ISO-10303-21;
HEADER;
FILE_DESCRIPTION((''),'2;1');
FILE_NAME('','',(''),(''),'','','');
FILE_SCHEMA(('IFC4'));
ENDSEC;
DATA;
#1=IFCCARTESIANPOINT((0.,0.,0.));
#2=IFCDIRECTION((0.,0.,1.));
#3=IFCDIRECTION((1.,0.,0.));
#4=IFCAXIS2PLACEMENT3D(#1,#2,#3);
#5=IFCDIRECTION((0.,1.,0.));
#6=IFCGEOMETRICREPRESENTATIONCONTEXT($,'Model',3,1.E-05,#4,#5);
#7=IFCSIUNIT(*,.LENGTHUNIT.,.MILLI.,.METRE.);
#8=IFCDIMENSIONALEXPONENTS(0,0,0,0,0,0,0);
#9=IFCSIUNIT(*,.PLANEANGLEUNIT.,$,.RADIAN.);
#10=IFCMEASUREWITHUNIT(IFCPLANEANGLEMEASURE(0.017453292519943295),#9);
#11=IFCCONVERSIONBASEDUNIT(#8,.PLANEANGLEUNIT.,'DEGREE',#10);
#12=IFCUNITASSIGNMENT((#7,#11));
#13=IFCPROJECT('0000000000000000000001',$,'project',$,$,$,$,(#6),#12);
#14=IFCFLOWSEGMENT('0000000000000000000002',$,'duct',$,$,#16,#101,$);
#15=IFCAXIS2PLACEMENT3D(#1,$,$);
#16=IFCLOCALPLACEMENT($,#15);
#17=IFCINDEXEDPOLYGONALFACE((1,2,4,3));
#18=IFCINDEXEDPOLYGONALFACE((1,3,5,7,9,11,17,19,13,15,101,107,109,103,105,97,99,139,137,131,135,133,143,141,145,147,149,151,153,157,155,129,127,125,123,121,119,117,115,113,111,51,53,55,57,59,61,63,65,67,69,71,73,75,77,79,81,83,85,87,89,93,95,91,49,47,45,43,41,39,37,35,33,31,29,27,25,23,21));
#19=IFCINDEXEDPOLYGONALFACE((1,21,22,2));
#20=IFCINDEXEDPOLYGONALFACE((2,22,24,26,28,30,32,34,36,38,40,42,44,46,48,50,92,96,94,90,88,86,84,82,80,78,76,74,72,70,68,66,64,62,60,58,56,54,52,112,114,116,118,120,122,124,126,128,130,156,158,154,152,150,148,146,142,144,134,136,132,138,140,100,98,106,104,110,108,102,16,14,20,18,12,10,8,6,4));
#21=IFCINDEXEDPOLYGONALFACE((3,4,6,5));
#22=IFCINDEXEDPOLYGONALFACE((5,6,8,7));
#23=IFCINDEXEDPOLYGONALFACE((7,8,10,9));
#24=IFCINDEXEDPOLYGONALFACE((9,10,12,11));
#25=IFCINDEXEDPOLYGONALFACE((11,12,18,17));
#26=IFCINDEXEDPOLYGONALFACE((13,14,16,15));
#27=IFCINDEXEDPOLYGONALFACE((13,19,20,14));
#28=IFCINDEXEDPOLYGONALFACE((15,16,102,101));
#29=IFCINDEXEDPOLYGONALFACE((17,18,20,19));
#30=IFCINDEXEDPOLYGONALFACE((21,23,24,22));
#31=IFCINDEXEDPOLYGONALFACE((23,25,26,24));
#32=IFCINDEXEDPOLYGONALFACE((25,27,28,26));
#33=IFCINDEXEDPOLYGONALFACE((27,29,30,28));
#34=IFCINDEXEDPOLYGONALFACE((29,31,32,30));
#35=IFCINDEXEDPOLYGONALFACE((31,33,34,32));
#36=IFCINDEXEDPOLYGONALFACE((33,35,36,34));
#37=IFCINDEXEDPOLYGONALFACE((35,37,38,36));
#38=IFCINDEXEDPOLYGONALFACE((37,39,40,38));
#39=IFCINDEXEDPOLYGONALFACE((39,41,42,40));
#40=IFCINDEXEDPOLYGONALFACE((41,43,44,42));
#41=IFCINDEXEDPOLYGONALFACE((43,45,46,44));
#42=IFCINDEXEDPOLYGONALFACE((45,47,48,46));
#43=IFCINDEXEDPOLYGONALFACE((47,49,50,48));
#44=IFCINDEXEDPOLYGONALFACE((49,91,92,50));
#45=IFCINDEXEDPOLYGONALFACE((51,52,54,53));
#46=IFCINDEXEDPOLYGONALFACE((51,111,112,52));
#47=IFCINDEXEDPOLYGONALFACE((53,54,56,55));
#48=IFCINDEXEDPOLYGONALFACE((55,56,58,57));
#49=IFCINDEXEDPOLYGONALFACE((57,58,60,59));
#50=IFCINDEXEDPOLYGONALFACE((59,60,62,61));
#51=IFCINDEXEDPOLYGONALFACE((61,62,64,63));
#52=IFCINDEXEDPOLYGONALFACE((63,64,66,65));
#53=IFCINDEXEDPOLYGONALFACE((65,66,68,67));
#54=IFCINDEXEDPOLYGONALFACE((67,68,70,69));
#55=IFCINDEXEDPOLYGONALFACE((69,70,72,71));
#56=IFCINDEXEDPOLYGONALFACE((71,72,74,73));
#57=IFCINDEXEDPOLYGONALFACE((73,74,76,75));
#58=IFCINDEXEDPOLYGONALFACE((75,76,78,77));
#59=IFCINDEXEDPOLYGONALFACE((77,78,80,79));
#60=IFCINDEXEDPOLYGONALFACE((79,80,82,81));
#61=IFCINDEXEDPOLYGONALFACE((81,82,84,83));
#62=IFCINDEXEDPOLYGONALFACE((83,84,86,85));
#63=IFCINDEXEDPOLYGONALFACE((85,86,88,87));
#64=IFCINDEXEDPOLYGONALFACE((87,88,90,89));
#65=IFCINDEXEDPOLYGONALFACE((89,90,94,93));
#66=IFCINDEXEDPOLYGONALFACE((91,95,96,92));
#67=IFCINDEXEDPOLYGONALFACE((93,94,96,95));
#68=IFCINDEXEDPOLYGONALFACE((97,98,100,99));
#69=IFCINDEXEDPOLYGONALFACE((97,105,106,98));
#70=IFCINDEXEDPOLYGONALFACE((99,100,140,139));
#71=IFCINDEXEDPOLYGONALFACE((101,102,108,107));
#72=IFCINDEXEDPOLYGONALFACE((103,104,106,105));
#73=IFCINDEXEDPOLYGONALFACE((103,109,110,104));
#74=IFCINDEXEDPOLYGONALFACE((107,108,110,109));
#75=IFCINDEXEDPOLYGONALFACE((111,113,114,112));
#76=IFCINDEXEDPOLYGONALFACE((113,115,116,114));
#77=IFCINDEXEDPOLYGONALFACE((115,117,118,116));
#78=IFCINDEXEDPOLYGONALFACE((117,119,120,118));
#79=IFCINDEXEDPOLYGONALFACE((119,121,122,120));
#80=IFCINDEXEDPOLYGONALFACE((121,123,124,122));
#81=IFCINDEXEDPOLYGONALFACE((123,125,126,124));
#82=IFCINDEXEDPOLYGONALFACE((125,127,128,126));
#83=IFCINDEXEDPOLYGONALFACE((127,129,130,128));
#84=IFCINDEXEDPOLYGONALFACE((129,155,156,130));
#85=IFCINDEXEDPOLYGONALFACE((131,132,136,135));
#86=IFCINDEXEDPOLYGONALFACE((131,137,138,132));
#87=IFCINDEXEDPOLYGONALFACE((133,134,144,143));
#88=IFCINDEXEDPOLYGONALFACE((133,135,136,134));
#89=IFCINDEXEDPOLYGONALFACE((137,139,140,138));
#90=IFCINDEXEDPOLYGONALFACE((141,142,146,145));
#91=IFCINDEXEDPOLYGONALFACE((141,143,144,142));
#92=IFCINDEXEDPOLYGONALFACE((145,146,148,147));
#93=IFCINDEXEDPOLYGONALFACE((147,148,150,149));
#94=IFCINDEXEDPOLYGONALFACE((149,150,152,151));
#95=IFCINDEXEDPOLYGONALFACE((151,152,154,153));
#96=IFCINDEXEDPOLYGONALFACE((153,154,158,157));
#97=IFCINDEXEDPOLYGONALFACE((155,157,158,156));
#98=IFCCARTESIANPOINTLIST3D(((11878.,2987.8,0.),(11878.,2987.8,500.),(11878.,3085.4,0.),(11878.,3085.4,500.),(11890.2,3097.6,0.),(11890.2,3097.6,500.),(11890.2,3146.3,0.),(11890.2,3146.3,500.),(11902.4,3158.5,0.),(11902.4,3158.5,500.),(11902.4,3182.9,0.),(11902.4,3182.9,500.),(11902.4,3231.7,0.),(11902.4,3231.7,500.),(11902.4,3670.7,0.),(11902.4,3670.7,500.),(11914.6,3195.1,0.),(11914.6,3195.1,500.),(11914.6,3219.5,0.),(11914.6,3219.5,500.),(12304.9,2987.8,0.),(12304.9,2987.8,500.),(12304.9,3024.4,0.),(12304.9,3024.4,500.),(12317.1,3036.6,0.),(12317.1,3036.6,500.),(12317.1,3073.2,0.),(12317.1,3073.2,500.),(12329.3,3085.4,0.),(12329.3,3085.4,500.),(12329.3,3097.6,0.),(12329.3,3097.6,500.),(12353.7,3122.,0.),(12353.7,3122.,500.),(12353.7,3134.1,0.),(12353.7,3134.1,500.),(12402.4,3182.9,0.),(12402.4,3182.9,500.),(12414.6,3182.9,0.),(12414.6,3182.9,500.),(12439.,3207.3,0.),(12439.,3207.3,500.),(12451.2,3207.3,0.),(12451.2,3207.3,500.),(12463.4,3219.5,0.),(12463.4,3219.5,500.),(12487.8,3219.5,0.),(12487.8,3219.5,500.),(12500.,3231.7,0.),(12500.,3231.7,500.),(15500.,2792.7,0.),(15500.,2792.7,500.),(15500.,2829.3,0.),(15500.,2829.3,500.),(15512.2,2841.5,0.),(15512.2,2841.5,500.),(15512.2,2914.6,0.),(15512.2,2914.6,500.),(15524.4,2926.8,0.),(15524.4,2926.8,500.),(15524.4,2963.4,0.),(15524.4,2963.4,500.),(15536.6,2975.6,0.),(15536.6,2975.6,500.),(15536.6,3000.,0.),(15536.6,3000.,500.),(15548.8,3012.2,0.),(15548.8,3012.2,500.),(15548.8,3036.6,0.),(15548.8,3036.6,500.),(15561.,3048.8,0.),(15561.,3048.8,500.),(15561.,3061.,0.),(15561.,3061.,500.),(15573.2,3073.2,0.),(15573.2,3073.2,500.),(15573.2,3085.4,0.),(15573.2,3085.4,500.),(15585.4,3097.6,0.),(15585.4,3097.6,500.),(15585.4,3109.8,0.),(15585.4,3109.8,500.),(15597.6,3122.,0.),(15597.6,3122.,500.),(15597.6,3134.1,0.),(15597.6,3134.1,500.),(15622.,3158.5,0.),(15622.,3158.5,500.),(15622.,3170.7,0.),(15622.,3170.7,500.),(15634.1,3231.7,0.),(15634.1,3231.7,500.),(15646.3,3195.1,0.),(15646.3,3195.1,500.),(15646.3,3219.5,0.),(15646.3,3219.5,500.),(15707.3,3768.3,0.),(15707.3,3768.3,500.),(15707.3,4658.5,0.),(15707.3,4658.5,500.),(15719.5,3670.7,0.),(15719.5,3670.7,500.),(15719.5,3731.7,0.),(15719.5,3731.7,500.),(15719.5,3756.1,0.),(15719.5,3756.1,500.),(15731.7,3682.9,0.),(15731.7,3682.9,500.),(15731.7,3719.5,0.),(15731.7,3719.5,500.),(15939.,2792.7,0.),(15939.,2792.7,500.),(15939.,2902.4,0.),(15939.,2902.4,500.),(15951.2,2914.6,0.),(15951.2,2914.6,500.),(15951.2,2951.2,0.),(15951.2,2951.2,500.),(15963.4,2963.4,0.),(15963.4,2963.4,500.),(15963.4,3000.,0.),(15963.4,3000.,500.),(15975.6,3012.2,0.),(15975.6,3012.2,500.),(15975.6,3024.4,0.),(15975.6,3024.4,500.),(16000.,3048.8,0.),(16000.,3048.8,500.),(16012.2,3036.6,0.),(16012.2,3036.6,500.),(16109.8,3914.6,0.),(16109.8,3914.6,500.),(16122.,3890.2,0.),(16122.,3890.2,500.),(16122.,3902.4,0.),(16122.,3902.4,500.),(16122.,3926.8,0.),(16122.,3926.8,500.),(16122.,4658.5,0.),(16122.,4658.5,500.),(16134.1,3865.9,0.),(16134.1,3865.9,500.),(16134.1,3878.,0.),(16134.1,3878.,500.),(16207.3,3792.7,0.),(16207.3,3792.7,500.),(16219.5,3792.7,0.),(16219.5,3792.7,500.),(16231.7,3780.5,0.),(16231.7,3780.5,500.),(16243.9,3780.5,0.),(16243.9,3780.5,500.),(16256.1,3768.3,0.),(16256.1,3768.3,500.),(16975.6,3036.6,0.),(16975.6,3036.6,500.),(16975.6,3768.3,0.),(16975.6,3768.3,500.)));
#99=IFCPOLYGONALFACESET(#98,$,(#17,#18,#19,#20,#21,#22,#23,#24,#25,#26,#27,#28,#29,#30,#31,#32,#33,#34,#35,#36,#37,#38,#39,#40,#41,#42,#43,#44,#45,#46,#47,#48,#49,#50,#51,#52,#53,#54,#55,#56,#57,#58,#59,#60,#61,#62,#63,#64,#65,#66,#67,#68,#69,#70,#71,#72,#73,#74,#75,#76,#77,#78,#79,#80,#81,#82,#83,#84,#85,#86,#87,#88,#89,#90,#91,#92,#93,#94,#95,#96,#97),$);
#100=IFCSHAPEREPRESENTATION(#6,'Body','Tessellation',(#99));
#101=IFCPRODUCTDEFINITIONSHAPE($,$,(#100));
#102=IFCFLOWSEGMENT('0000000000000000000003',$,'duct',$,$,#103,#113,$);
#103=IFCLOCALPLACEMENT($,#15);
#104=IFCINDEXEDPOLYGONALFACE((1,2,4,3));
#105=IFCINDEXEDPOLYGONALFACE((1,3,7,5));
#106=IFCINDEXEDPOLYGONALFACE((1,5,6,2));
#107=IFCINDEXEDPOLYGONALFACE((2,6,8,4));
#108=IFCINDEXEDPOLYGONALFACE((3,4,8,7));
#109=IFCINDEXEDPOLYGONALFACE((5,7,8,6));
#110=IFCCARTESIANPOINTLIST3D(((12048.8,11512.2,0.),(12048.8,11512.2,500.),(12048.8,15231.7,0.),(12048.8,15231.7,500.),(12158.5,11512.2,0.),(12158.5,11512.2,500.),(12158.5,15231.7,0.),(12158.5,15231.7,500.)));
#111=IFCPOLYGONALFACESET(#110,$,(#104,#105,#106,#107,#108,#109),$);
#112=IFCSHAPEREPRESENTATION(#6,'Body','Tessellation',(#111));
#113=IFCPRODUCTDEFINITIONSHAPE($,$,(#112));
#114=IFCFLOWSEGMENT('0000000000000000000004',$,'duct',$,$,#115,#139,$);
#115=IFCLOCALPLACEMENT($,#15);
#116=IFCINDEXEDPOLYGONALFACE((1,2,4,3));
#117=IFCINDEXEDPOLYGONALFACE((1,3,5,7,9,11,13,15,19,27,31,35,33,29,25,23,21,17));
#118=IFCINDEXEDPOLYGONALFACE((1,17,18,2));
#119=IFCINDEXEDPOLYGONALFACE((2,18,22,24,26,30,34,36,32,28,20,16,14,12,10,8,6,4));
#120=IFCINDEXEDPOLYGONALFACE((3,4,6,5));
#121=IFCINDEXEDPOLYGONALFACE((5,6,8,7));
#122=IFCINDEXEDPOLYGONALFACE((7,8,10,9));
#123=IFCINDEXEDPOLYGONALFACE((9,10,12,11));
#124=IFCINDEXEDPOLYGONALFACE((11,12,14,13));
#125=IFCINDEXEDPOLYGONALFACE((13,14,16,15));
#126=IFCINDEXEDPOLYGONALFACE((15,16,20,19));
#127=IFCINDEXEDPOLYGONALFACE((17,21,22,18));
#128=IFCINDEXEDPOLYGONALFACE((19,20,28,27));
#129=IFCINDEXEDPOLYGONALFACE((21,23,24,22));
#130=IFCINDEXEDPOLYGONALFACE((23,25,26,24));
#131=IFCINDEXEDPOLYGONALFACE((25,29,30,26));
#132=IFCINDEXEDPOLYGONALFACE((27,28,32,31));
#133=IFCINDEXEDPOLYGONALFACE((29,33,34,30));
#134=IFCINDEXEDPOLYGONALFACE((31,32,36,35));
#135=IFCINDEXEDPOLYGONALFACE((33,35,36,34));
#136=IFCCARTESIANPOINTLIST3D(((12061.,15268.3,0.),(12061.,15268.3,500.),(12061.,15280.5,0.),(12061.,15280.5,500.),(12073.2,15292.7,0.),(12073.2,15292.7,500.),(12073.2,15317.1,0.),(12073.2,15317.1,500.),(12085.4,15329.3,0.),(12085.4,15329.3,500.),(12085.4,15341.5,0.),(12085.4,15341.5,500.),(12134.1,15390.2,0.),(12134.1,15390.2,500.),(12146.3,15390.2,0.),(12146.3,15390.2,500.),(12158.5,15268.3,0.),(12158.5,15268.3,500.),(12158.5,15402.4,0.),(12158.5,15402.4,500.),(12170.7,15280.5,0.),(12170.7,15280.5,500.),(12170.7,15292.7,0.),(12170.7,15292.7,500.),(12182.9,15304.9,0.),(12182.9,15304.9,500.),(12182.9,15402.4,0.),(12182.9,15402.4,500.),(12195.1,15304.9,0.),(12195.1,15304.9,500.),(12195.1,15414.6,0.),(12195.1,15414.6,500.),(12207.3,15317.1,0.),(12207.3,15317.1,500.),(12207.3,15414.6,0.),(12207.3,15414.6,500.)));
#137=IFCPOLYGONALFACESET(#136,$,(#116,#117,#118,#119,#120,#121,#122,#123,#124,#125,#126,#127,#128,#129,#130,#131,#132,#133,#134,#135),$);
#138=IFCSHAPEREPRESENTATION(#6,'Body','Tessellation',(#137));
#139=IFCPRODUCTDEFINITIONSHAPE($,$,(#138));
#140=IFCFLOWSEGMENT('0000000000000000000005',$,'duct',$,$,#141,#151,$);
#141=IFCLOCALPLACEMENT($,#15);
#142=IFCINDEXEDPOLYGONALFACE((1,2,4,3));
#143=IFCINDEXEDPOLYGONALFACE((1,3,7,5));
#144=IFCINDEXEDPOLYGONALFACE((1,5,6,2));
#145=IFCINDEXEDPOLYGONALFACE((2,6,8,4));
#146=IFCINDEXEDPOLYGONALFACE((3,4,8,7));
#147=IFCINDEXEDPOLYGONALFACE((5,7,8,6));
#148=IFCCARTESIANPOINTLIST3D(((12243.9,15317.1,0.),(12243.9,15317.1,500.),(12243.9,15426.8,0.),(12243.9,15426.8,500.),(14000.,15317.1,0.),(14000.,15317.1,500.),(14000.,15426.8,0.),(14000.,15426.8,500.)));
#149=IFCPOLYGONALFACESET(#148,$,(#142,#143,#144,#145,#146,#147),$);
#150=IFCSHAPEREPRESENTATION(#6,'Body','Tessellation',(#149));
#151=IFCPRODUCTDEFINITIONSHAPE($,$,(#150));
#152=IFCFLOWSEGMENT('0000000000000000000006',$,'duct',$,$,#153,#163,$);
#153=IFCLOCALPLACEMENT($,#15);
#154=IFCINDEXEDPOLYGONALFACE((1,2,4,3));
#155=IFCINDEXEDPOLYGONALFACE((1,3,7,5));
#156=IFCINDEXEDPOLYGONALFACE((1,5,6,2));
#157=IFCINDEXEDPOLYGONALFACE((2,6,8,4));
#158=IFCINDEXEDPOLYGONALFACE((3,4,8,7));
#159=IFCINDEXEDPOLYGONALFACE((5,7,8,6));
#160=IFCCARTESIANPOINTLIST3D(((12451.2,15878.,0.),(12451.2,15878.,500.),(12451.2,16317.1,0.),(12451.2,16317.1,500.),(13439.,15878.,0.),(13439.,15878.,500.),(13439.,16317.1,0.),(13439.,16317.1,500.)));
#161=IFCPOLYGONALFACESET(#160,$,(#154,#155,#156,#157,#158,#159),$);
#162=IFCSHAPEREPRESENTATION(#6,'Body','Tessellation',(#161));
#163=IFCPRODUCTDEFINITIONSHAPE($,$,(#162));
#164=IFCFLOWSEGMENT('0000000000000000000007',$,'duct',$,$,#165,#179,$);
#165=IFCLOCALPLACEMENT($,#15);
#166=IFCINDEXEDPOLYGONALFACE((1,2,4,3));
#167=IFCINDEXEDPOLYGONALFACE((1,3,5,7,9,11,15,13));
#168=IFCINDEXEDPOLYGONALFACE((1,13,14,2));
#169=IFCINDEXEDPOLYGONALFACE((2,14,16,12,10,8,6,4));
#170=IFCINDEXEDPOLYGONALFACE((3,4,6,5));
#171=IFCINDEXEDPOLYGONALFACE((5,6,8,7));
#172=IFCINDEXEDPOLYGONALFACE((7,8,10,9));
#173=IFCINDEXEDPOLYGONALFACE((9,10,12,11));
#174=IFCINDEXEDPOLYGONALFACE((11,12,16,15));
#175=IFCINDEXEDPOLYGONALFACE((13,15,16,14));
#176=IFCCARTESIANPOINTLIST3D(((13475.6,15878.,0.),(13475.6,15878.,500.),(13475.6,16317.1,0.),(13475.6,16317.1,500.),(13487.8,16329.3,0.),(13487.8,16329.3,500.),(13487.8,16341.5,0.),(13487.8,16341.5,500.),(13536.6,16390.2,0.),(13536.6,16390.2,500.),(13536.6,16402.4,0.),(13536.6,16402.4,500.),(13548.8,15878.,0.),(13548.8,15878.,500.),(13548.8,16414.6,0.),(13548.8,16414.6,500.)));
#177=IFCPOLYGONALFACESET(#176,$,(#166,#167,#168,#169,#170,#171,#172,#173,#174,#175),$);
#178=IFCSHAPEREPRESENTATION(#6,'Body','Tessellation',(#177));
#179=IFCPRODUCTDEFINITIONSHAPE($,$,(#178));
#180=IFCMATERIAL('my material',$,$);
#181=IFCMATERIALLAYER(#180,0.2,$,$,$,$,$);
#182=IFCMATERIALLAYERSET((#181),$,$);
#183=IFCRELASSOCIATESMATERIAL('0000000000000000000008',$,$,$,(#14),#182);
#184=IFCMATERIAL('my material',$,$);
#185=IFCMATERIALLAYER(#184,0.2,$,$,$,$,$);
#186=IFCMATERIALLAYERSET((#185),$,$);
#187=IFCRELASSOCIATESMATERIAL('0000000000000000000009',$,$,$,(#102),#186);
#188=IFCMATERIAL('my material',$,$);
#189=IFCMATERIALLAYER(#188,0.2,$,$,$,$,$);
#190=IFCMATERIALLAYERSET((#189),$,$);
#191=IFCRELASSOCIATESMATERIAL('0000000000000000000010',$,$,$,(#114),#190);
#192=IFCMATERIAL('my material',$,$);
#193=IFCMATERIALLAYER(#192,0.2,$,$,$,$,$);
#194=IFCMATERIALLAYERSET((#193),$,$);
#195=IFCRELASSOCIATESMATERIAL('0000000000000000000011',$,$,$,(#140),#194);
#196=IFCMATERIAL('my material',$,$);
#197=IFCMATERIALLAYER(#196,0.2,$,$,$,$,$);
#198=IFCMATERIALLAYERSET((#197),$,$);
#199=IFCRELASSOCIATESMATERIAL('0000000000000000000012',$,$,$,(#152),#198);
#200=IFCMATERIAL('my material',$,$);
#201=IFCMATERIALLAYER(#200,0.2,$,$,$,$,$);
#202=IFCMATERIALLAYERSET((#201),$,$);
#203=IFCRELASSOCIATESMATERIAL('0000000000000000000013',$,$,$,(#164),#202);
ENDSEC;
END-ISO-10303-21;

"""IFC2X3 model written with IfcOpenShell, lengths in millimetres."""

from ifc_helpers import new_model, entity, si_unit, converted_unit, direction, origin_with_axes, place, context, project, polyline, outline, extrude, material, layer, layer_set, layer_usage, element, save


model = new_model("IFC2X3")

# Units and contexts
model_context = context("Model", 3, precision=1e-05, world=origin_with_axes(), true_north=direction((0.0, 1.0, 0.0)))
ifc_project = project(units=[si_unit("LENGTHUNIT", "METRE", prefix="MILLI"), converted_unit("PLANEANGLEUNIT", "DEGREE", entity("IfcPlaneAngleMeasure", 0.017453292519943295), si_unit("PLANEANGLEUNIT", "RADIAN"), dimensions=[0, 0, 0, 0, 0, 0, 0])], contexts=[model_context])

# Flow segments
ifc_material_1 = material(Name="my material")
ifc_layer_1 = layer(ifc_material_1, 0.2)
ifc_layer_set_1 = layer_set([ifc_layer_1])
ifc_layer_usage_1 = layer_usage(ifc_layer_set_1, "AXIS2", "POSITIVE", -0.1)
flow_segment_1_placement = place(None, origin_with_axes())
element("IfcFlowSegment", 1, at=flow_segment_1_placement, material=ifc_layer_usage_1, Name="duct", context=model_context, shape_type="SweptSolid", body=[
    extrude(outline(polyline([(11878.0, 2987.8), (12304.9, 2987.8), (12304.9, 3024.4), (12317.1, 3036.6), (12317.1, 3073.2), (12329.3, 3085.4), (12329.3, 3097.6), (12353.7, 3122.0), (12353.7, 3134.1), (12402.4, 3182.9), (12414.6, 3182.9), (12439.0, 3207.3), (12451.2, 3207.3), (12463.4, 3219.5), (12487.8, 3219.5), (12500.0, 3231.7), (15634.1, 3231.7), (15646.3, 3219.5), (15646.3, 3195.1), (15622.0, 3170.7), (15622.0, 3158.5), (15597.6, 3134.1), (15597.6, 3122.0), (15585.4, 3109.8), (15585.4, 3097.6), (15573.2, 3085.4), (15573.2, 3073.2), (15561.0, 3061.0), (15561.0, 3048.8), (15548.8, 3036.6), (15548.8, 3012.2), (15536.6, 3000.0), (15536.6, 2975.6), (15524.4, 2963.4), (15524.4, 2926.8), (15512.2, 2914.6), (15512.2, 2841.5), (15500.0, 2829.3), (15500.0, 2792.7), (15939.0, 2792.7), (15939.0, 2902.4), (15951.2, 2914.6), (15951.2, 2951.2), (15963.4, 2963.4), (15963.4, 3000.0), (15975.6, 3012.2), (15975.6, 3024.4), (16000.0, 3048.8), (16012.2, 3036.6), (16975.6, 3036.6), (16975.6, 3768.3), (16256.1, 3768.3), (16243.9, 3780.5), (16231.7, 3780.5), (16219.5, 3792.7), (16207.3, 3792.7), (16134.1, 3865.9), (16134.1, 3878.0), (16122.0, 3890.2), (16122.0, 3902.4), (16109.8, 3914.6), (16122.0, 3926.8), (16122.0, 4658.5), (15707.3, 4658.5), (15707.3, 3768.3), (15719.5, 3756.1), (15719.5, 3731.7), (15731.7, 3719.5), (15731.7, 3682.9), (15719.5, 3670.7), (11902.4, 3670.7), (11902.4, 3231.7), (11914.6, 3219.5), (11914.6, 3195.1), (11902.4, 3182.9), (11902.4, 3158.5), (11890.2, 3146.3), (11890.2, 3097.6), (11878.0, 3085.4), (11878.0, 2987.8)])), origin_with_axes(), (0.0, 0.0, 1.0), 500.0),
])
ifc_material_2 = material(Name="my material")
ifc_layer_2 = layer(ifc_material_2, 0.2)
ifc_layer_set_2 = layer_set([ifc_layer_2])
ifc_layer_usage_2 = layer_usage(ifc_layer_set_2, "AXIS2", "POSITIVE", -0.1)
flow_segment_2_placement = place(None, origin_with_axes())
element("IfcFlowSegment", 2, at=flow_segment_2_placement, material=ifc_layer_usage_2, Name="duct", context=model_context, shape_type="SweptSolid", body=[
    extrude(outline(polyline([(12048.8, 11512.2), (12158.5, 11512.2), (12158.5, 15231.7), (12048.8, 15231.7), (12048.8, 11512.2)])), origin_with_axes(), (0.0, 0.0, 1.0), 500.0),
])
ifc_material_3 = material(Name="my material")
ifc_layer_3 = layer(ifc_material_3, 0.2)
ifc_layer_set_3 = layer_set([ifc_layer_3])
ifc_layer_usage_3 = layer_usage(ifc_layer_set_3, "AXIS2", "POSITIVE", -0.1)
flow_segment_3_placement = place(None, origin_with_axes())
element("IfcFlowSegment", 3, at=flow_segment_3_placement, material=ifc_layer_usage_3, Name="duct", context=model_context, shape_type="SweptSolid", body=[
    extrude(outline(polyline([(12061.0, 15268.3), (12158.5, 15268.3), (12170.7, 15280.5), (12170.7, 15292.7), (12182.9, 15304.9), (12195.1, 15304.9), (12207.3, 15317.1), (12207.3, 15414.6), (12195.1, 15414.6), (12182.9, 15402.4), (12158.5, 15402.4), (12146.3, 15390.2), (12134.1, 15390.2), (12085.4, 15341.5), (12085.4, 15329.3), (12073.2, 15317.1), (12073.2, 15292.7), (12061.0, 15280.5), (12061.0, 15268.3)])), origin_with_axes(), (0.0, 0.0, 1.0), 500.0),
])
ifc_material_4 = material(Name="my material")
ifc_layer_4 = layer(ifc_material_4, 0.2)
ifc_layer_set_4 = layer_set([ifc_layer_4])
ifc_layer_usage_4 = layer_usage(ifc_layer_set_4, "AXIS2", "POSITIVE", -0.1)
flow_segment_4_placement = place(None, origin_with_axes())
element("IfcFlowSegment", 4, at=flow_segment_4_placement, material=ifc_layer_usage_4, Name="duct", context=model_context, shape_type="SweptSolid", body=[
    extrude(outline(polyline([(12243.9, 15317.1), (14000.0, 15317.1), (14000.0, 15426.8), (12243.9, 15426.8), (12243.9, 15317.1)])), origin_with_axes(), (0.0, 0.0, 1.0), 500.0),
])
ifc_material_5 = material(Name="my material")
ifc_layer_5 = layer(ifc_material_5, 0.2)
ifc_layer_set_5 = layer_set([ifc_layer_5])
ifc_layer_usage_5 = layer_usage(ifc_layer_set_5, "AXIS2", "POSITIVE", -0.1)
flow_segment_5_placement = place(None, origin_with_axes())
element("IfcFlowSegment", 5, at=flow_segment_5_placement, material=ifc_layer_usage_5, Name="duct", context=model_context, shape_type="SweptSolid", body=[
    extrude(outline(polyline([(12451.2, 15878.0), (13439.0, 15878.0), (13439.0, 16317.1), (12451.2, 16317.1), (12451.2, 15878.0)])), origin_with_axes(), (0.0, 0.0, 1.0), 500.0),
])
ifc_material_6 = material(Name="my material")
ifc_layer_6 = layer(ifc_material_6, 0.2)
ifc_layer_set_6 = layer_set([ifc_layer_6])
ifc_layer_usage_6 = layer_usage(ifc_layer_set_6, "AXIS2", "POSITIVE", -0.1)
flow_segment_6_placement = place(None, origin_with_axes())
element("IfcFlowSegment", 6, at=flow_segment_6_placement, material=ifc_layer_usage_6, Name="duct", context=model_context, shape_type="SweptSolid", body=[
    extrude(outline(polyline([(13475.6, 15878.0), (13548.8, 15878.0), (13548.8, 16414.6), (13536.6, 16402.4), (13536.6, 16390.2), (13487.8, 16341.5), (13487.8, 16329.3), (13475.6, 16317.1), (13475.6, 15878.0)])), origin_with_axes(), (0.0, 0.0, 1.0), 500.0),
])

save(model, "model.ifc")
